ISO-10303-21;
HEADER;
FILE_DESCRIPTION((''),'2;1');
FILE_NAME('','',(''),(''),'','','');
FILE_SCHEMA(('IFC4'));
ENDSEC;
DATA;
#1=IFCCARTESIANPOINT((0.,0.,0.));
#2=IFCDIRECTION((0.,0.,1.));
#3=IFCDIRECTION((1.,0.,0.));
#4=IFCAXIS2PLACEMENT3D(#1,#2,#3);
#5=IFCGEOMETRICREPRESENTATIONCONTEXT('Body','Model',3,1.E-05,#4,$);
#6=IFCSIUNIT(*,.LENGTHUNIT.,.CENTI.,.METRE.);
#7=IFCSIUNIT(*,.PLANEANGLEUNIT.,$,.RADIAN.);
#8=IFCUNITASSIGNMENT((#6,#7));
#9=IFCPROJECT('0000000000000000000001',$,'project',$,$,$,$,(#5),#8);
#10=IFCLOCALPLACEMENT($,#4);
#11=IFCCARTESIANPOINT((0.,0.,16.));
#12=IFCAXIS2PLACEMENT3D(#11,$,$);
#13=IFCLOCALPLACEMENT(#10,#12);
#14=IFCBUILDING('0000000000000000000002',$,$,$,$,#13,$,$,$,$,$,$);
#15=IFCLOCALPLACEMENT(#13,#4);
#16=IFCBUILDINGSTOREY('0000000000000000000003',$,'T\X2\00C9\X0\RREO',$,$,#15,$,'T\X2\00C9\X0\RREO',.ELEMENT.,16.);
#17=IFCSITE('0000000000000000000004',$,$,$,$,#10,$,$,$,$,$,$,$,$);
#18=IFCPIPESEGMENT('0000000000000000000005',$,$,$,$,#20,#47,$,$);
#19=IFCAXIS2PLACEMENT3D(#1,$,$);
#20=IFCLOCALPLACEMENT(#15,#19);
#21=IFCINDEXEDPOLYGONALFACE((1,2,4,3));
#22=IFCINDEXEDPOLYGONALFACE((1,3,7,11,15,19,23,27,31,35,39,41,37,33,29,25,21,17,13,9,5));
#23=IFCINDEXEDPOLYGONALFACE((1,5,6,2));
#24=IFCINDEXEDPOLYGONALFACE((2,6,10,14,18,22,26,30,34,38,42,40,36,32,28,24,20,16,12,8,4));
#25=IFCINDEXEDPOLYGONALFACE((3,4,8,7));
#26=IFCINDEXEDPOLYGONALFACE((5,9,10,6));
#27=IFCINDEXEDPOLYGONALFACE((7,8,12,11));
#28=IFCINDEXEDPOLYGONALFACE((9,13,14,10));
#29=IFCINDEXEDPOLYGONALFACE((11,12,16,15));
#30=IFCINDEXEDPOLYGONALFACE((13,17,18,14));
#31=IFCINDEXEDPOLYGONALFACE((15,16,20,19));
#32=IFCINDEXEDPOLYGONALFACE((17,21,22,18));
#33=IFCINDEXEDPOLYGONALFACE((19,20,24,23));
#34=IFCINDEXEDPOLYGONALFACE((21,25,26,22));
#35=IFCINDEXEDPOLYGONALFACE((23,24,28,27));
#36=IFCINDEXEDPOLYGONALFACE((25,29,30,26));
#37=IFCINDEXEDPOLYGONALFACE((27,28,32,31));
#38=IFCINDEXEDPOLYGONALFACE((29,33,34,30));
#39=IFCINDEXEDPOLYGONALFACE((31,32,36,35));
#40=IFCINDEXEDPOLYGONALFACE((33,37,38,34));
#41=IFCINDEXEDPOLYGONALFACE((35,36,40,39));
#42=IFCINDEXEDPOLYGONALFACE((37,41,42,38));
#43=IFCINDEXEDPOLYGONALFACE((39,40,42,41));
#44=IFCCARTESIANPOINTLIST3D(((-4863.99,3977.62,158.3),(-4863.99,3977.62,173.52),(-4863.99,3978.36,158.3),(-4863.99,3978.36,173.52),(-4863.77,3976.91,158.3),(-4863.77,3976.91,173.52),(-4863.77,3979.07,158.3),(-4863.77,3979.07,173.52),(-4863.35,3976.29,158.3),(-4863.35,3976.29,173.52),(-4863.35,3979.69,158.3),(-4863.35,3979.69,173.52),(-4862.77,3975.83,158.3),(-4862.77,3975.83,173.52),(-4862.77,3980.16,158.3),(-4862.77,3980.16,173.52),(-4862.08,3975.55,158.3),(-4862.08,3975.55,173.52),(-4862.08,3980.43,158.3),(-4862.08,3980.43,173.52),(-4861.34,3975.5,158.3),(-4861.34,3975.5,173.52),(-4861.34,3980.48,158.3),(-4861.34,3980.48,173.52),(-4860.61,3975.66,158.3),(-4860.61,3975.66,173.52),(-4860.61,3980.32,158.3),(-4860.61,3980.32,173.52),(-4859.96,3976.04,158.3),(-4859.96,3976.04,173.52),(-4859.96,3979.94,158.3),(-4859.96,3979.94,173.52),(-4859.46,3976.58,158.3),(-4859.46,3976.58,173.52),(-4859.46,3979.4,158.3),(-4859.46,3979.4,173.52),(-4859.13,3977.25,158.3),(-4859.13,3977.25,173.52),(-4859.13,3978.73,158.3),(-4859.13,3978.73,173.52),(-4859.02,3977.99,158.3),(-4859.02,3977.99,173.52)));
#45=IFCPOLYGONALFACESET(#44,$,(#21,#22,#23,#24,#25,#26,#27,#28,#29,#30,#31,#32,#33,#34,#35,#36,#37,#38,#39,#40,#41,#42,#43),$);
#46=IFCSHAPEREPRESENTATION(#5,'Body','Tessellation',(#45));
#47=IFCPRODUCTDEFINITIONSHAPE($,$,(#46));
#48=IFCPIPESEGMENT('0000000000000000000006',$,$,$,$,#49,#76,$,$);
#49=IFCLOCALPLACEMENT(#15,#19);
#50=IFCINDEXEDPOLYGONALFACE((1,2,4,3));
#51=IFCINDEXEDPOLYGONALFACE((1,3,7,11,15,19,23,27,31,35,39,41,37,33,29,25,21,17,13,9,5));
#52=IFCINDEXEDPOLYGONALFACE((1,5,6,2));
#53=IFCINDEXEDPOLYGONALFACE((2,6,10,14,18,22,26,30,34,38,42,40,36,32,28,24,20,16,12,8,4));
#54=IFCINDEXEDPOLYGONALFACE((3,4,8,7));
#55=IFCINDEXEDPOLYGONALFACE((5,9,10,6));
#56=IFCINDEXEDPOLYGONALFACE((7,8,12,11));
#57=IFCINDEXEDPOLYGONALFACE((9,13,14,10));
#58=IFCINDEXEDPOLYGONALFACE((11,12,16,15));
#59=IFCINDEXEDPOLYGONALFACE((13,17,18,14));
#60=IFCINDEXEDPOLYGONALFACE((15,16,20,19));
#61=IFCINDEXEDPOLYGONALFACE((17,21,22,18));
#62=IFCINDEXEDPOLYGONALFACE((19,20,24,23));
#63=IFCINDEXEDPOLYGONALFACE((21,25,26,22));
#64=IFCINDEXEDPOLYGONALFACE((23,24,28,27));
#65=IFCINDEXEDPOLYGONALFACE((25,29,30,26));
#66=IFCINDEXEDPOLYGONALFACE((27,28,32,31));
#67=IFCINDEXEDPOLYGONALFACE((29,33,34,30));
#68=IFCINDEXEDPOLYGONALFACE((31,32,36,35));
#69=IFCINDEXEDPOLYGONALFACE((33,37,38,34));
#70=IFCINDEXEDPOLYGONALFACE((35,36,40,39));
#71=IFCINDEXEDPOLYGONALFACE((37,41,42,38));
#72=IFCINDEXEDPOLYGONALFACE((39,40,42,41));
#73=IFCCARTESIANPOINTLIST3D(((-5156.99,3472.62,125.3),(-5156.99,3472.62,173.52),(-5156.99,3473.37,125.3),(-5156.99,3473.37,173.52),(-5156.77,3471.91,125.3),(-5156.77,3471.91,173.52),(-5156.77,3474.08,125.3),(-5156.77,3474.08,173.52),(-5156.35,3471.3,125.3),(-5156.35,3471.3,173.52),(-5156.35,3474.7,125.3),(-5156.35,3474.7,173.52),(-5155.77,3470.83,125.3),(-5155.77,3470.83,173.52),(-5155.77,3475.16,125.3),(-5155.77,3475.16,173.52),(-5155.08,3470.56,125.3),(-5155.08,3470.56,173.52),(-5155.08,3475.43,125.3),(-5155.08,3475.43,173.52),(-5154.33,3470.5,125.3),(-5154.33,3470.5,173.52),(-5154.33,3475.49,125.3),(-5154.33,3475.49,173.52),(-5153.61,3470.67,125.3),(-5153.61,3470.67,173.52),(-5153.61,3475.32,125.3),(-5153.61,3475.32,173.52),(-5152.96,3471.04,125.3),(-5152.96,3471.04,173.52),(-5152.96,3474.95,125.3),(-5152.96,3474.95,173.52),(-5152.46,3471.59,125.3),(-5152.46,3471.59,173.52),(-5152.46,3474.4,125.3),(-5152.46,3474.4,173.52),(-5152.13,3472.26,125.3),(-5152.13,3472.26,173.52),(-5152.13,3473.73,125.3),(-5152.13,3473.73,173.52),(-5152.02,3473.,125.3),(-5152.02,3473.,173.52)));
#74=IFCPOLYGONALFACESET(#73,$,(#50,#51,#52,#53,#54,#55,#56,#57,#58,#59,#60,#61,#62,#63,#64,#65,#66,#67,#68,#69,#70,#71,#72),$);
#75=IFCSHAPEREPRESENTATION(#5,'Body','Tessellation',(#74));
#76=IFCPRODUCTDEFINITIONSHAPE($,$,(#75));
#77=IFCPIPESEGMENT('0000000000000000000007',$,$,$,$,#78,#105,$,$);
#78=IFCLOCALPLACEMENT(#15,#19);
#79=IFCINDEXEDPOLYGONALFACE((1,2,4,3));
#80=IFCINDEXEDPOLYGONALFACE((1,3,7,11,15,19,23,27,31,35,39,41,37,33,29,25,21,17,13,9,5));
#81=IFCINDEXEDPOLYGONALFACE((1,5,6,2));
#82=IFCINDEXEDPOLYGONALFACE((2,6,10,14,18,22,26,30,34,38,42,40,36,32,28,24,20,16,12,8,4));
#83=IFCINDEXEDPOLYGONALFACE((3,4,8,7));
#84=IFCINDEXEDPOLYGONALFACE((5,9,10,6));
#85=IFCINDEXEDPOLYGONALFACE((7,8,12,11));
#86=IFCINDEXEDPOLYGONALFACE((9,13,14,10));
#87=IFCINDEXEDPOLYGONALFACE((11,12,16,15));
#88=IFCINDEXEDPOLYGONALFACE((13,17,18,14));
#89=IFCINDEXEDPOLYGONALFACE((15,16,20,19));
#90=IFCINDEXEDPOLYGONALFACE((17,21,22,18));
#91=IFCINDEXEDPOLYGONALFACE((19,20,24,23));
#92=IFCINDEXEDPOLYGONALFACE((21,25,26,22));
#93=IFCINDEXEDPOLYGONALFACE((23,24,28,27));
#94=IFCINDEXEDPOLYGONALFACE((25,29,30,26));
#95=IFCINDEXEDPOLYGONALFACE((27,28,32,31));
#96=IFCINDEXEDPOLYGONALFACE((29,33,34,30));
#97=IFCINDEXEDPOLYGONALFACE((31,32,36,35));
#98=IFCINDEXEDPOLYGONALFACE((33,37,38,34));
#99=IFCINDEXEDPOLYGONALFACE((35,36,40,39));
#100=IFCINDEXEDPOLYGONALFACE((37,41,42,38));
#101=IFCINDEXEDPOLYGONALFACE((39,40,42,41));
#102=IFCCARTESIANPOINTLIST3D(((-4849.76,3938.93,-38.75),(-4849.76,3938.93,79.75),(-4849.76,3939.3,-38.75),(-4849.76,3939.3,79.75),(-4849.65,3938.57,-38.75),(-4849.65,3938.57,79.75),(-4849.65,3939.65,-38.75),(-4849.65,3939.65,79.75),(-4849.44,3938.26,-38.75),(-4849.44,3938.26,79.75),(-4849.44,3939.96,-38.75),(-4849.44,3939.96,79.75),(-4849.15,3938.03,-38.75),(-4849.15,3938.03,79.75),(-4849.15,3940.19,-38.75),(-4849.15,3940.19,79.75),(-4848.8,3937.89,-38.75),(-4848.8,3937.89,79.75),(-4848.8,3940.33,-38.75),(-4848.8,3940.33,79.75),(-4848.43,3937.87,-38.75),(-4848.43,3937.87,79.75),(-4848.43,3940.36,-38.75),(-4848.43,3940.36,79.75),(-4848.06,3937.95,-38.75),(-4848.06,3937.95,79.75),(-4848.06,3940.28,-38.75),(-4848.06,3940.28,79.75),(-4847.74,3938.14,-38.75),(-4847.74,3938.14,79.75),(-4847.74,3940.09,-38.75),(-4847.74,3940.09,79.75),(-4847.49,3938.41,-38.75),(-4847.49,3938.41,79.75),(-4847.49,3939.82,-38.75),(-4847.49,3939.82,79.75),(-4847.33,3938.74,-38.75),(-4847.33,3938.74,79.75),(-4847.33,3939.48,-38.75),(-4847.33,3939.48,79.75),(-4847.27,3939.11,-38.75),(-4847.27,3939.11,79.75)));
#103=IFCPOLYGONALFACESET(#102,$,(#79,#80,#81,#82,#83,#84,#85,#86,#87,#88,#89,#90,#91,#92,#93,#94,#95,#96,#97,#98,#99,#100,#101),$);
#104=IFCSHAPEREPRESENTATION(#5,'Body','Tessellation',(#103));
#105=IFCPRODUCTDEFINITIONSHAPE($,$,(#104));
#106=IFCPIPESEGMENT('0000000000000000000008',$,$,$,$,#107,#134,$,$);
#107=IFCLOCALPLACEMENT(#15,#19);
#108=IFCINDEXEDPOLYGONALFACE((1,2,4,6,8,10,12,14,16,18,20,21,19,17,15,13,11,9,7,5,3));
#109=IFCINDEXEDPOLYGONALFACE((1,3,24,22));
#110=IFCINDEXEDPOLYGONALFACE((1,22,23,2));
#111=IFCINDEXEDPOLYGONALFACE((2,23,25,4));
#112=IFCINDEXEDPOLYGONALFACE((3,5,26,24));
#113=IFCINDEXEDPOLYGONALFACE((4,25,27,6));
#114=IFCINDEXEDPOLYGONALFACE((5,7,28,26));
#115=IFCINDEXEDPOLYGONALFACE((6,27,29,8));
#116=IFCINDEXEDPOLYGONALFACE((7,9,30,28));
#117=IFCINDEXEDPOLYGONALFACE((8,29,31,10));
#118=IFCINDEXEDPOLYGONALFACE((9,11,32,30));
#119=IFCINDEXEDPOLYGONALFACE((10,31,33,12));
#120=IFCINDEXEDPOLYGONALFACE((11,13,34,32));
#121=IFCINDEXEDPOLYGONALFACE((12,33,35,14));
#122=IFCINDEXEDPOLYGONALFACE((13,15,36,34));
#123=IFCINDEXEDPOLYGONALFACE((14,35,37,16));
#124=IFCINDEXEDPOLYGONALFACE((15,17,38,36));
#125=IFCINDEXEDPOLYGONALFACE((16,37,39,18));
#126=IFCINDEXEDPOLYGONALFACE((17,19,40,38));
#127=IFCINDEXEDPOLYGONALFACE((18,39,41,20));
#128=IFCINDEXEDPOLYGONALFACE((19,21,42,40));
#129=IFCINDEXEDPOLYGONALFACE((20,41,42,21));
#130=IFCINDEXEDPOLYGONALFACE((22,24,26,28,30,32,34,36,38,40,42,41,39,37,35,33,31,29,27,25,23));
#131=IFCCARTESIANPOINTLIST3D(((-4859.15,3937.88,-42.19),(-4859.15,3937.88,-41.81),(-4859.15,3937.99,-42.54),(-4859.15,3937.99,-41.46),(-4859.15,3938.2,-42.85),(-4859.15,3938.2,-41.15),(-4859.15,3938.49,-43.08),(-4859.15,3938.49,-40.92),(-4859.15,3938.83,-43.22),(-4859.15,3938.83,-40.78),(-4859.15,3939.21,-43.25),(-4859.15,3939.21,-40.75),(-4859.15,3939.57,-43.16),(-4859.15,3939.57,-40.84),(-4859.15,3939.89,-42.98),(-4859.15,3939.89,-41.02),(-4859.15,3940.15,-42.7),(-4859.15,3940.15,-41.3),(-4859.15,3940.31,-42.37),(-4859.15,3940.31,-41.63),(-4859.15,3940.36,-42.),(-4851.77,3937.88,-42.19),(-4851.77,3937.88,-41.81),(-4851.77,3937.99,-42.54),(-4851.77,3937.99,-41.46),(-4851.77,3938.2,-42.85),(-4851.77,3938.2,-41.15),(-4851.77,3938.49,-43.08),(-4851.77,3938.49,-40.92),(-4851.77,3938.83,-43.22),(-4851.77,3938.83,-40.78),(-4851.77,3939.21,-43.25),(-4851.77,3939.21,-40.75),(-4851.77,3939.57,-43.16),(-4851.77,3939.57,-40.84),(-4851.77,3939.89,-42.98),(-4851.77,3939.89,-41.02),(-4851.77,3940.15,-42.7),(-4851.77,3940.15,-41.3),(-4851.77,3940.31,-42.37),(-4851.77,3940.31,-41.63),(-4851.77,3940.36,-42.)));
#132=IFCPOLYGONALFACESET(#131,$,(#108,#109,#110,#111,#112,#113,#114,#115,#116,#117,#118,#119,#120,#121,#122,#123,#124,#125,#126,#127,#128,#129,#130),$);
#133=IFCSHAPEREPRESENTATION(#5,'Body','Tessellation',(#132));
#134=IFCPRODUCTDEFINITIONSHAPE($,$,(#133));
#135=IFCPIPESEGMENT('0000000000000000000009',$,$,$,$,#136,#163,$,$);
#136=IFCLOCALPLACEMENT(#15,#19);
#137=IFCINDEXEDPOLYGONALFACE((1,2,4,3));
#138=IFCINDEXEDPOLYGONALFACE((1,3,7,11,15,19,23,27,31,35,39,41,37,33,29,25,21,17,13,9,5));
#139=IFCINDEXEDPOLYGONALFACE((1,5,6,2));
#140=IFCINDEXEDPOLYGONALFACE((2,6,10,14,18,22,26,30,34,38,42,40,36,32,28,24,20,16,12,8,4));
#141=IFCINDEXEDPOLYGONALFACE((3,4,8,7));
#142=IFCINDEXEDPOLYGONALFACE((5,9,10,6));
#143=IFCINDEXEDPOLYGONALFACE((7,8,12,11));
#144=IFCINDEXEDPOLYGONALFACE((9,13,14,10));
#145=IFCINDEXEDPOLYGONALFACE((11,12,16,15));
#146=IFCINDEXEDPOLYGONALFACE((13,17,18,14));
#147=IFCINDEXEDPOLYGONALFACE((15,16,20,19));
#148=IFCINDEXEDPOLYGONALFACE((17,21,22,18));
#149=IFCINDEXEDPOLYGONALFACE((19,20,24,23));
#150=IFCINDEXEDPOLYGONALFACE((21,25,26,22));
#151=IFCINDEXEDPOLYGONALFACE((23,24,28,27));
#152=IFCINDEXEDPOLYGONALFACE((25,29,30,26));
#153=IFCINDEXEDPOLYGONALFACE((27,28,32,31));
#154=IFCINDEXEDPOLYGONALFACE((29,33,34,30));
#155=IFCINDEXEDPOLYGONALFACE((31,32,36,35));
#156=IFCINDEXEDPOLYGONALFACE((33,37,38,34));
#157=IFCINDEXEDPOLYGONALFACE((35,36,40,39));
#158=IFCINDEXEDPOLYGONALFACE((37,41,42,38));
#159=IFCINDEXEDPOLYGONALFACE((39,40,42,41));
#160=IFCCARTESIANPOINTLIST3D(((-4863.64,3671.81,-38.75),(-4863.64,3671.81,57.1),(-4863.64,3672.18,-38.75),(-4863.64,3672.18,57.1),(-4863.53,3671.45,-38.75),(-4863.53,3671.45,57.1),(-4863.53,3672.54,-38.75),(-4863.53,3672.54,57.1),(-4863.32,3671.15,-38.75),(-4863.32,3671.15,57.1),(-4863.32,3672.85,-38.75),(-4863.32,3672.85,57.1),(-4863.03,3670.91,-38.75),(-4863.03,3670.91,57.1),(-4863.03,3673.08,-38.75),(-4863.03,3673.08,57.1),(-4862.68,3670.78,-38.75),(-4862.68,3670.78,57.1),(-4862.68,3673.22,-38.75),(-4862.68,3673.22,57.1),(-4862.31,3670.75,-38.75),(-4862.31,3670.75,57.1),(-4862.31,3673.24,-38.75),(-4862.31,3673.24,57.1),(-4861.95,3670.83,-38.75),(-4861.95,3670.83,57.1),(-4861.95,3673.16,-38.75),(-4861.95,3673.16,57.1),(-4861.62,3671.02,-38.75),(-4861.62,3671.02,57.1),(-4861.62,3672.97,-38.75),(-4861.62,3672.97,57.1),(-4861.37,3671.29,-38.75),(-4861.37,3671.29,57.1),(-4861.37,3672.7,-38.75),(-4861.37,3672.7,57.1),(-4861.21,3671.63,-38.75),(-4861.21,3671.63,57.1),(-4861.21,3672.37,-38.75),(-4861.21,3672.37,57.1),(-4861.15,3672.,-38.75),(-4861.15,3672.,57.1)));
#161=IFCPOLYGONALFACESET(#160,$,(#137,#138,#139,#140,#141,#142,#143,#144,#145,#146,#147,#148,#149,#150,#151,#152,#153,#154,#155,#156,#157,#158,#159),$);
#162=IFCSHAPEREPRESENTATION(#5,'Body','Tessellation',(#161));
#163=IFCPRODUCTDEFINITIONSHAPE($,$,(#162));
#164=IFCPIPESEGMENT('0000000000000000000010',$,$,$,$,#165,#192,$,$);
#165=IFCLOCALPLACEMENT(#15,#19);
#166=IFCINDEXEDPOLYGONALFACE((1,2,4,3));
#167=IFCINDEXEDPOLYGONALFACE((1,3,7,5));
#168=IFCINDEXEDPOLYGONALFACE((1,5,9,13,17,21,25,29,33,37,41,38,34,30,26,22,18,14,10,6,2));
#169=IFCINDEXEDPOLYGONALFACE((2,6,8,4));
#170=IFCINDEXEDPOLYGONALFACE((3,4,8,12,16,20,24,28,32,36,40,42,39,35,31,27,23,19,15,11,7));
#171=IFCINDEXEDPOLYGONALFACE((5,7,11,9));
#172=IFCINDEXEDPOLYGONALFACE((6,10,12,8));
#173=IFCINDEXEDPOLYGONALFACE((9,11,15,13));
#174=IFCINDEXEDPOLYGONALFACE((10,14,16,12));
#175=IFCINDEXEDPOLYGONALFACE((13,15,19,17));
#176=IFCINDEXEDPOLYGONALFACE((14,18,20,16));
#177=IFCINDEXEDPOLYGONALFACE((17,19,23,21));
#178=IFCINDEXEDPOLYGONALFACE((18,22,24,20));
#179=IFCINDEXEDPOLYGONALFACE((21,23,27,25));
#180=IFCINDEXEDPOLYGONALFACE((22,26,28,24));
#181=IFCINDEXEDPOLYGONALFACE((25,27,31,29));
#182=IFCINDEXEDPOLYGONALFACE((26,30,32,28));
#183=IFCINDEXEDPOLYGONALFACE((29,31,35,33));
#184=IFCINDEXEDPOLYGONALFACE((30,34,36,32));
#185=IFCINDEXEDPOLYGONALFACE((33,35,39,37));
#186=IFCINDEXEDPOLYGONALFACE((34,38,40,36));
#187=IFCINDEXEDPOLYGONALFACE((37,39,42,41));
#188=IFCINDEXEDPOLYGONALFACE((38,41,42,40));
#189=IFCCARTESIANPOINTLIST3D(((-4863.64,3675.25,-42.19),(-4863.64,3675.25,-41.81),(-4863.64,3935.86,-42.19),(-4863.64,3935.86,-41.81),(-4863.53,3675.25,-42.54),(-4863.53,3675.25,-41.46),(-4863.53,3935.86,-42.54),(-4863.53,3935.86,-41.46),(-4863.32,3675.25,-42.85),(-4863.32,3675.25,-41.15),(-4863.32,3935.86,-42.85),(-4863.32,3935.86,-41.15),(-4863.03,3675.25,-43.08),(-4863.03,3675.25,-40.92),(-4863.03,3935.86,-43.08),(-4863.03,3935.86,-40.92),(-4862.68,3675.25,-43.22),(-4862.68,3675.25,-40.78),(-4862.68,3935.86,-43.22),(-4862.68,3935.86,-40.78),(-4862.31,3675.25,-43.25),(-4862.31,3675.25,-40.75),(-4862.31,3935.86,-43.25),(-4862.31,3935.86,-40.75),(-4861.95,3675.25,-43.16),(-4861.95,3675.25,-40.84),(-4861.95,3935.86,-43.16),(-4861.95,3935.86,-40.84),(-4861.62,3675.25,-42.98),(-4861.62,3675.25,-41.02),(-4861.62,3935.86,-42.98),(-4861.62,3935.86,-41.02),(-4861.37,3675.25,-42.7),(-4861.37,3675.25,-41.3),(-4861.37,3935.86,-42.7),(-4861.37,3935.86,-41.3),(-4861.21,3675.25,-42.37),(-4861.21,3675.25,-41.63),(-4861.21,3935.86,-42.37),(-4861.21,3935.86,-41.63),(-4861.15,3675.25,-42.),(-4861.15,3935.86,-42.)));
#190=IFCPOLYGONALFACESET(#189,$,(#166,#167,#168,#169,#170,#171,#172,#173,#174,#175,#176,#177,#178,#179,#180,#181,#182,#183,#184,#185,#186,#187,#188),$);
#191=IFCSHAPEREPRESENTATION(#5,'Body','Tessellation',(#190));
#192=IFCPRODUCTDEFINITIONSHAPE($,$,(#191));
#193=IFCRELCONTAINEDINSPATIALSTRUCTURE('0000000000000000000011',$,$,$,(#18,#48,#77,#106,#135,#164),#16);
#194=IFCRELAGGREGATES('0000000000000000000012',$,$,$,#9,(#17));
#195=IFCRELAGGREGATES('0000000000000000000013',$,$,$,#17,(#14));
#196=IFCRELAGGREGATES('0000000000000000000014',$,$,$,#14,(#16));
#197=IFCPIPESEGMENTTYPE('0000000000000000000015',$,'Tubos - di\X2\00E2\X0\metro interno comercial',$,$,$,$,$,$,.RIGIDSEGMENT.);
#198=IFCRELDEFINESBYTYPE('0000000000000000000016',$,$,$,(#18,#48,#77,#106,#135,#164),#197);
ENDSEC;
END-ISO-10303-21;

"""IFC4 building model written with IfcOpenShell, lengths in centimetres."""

from ifc_helpers import new_model, si_unit, frame, origin_with_axes, origin_2d_with_axis, place, context, project, spatial, circle, extrude, type_object, element, save


model = new_model("IFC4")

# Units and contexts
model_context = context("Model", 3, precision=1e-05, world=origin_with_axes(), identifier="Body")
ifc_project = project(units=[si_unit("LENGTHUNIT", "METRE", prefix="CENTI"), si_unit("PLANEANGLEUNIT", "RADIAN")], contexts=[model_context])

# Site, building, storey
site_placement = place(None, origin_with_axes())
site = spatial("IfcSite", under=ifc_project, at=site_placement)
building_placement = place(site_placement, frame((0.0, 0.0, 16.0)))
building = spatial("IfcBuilding", under=site, at=building_placement)
storey_placement = place(building_placement, origin_with_axes())
storey = spatial("IfcBuildingStorey", under=building, at=storey_placement, Name="TÉRREO", LongName="TÉRREO", CompositionType="ELEMENT", Elevation=16.0)

# Pipe segments
pipe_segment_type = type_object("IfcPipeSegmentType", Name="Tubos - diâmetro interno comercial", PredefinedType="RIGIDSEGMENT")
pipe_segment_1_placement = place(storey_placement, frame((-4861.52, 3977.99, 173.52), z_axis=(0.0, 0.0, 1.0), x_axis=(1.0, 0.0, 0.0)))
element("IfcPipeSegment", 1, at=pipe_segment_1_placement, inside=storey, type_object=pipe_segment_type, context=model_context, shape_type="SolidModel", body=[
    extrude(circle(Radius=2.5, at=origin_2d_with_axis()), frame((0.0, 0.0, 0.0), z_axis=(0.0, 0.0, -1.0), x_axis=(1.0, 0.0, 0.0)), (0.0, 0.0, 1.0), 15.22),
])
pipe_segment_2_placement = place(storey_placement, frame((-5154.52, 3473.0, 173.52), z_axis=(0.0, 0.0, 1.0), x_axis=(1.0, 0.0, 0.0)))
element("IfcPipeSegment", 2, at=pipe_segment_2_placement, inside=storey, type_object=pipe_segment_type, context=model_context, shape_type="SolidModel", body=[
    extrude(circle(Radius=2.5, at=origin_2d_with_axis()), frame((0.0, 0.0, 0.0), z_axis=(0.0, 0.0, -1.0), x_axis=(1.0, 0.0, 0.0)), (0.0, 0.0, 1.0), 48.22),
])
pipe_segment_3_placement = place(storey_placement, frame((-4848.52, 3939.11, 79.75), z_axis=(0.0, 0.0, 1.0), x_axis=(1.0, 0.0, 0.0)))
element("IfcPipeSegment", 3, at=pipe_segment_3_placement, inside=storey, type_object=pipe_segment_type, context=model_context, shape_type="SolidModel", body=[
    extrude(circle(Radius=1.25, at=origin_2d_with_axis()), frame((0.0, 0.0, 0.0), z_axis=(0.0, 0.0, -1.0), x_axis=(1.0, 0.0, 0.0)), (0.0, 0.0, 1.0), 118.5),
])
pipe_segment_4_placement = place(storey_placement, frame((-4855.46, 3939.11, -40.75), z_axis=(0.0, 0.0, 1.0), x_axis=(1.0, 0.0, 0.0)))
element("IfcPipeSegment", 4, at=pipe_segment_4_placement, inside=storey, type_object=pipe_segment_type, context=model_context, shape_type="SolidModel", body=[
    extrude(circle(Radius=1.25, at=origin_2d_with_axis()), frame((3.69, 0.0, -1.25), z_axis=(-1.0, 0.0, 0.0), x_axis=(0.0, 1.0, 0.0)), (0.0, 0.0, 1.0), 7.38),
])
pipe_segment_5_placement = place(storey_placement, frame((-4862.4, 3672.0, 57.1), z_axis=(0.0, 0.0, 1.0), x_axis=(1.0, 0.0, 0.0)))
element("IfcPipeSegment", 5, at=pipe_segment_5_placement, inside=storey, type_object=pipe_segment_type, context=model_context, shape_type="SolidModel", body=[
    extrude(circle(Radius=1.25, at=origin_2d_with_axis()), frame((0.0, 0.0, -95.85), z_axis=(0.0, 0.0, 1.0), x_axis=(1.0, 0.0, 0.0)), (0.0, 0.0, 1.0), 95.85),
])
pipe_segment_6_placement = place(storey_placement, frame((-4862.4, 3805.55, -40.75), z_axis=(0.0, 0.0, 1.0), x_axis=(1.0, 0.0, 0.0)))
element("IfcPipeSegment", 6, at=pipe_segment_6_placement, inside=storey, type_object=pipe_segment_type, context=model_context, shape_type="SolidModel", body=[
    extrude(circle(Radius=1.25, at=origin_2d_with_axis()), frame((0.0, 130.31, -1.25), z_axis=(0.0, -1.0, 0.0), x_axis=(1.0, 0.0, 0.0)), (0.0, 0.0, 1.0), 260.62),
])

save(model, "model.ifc")
